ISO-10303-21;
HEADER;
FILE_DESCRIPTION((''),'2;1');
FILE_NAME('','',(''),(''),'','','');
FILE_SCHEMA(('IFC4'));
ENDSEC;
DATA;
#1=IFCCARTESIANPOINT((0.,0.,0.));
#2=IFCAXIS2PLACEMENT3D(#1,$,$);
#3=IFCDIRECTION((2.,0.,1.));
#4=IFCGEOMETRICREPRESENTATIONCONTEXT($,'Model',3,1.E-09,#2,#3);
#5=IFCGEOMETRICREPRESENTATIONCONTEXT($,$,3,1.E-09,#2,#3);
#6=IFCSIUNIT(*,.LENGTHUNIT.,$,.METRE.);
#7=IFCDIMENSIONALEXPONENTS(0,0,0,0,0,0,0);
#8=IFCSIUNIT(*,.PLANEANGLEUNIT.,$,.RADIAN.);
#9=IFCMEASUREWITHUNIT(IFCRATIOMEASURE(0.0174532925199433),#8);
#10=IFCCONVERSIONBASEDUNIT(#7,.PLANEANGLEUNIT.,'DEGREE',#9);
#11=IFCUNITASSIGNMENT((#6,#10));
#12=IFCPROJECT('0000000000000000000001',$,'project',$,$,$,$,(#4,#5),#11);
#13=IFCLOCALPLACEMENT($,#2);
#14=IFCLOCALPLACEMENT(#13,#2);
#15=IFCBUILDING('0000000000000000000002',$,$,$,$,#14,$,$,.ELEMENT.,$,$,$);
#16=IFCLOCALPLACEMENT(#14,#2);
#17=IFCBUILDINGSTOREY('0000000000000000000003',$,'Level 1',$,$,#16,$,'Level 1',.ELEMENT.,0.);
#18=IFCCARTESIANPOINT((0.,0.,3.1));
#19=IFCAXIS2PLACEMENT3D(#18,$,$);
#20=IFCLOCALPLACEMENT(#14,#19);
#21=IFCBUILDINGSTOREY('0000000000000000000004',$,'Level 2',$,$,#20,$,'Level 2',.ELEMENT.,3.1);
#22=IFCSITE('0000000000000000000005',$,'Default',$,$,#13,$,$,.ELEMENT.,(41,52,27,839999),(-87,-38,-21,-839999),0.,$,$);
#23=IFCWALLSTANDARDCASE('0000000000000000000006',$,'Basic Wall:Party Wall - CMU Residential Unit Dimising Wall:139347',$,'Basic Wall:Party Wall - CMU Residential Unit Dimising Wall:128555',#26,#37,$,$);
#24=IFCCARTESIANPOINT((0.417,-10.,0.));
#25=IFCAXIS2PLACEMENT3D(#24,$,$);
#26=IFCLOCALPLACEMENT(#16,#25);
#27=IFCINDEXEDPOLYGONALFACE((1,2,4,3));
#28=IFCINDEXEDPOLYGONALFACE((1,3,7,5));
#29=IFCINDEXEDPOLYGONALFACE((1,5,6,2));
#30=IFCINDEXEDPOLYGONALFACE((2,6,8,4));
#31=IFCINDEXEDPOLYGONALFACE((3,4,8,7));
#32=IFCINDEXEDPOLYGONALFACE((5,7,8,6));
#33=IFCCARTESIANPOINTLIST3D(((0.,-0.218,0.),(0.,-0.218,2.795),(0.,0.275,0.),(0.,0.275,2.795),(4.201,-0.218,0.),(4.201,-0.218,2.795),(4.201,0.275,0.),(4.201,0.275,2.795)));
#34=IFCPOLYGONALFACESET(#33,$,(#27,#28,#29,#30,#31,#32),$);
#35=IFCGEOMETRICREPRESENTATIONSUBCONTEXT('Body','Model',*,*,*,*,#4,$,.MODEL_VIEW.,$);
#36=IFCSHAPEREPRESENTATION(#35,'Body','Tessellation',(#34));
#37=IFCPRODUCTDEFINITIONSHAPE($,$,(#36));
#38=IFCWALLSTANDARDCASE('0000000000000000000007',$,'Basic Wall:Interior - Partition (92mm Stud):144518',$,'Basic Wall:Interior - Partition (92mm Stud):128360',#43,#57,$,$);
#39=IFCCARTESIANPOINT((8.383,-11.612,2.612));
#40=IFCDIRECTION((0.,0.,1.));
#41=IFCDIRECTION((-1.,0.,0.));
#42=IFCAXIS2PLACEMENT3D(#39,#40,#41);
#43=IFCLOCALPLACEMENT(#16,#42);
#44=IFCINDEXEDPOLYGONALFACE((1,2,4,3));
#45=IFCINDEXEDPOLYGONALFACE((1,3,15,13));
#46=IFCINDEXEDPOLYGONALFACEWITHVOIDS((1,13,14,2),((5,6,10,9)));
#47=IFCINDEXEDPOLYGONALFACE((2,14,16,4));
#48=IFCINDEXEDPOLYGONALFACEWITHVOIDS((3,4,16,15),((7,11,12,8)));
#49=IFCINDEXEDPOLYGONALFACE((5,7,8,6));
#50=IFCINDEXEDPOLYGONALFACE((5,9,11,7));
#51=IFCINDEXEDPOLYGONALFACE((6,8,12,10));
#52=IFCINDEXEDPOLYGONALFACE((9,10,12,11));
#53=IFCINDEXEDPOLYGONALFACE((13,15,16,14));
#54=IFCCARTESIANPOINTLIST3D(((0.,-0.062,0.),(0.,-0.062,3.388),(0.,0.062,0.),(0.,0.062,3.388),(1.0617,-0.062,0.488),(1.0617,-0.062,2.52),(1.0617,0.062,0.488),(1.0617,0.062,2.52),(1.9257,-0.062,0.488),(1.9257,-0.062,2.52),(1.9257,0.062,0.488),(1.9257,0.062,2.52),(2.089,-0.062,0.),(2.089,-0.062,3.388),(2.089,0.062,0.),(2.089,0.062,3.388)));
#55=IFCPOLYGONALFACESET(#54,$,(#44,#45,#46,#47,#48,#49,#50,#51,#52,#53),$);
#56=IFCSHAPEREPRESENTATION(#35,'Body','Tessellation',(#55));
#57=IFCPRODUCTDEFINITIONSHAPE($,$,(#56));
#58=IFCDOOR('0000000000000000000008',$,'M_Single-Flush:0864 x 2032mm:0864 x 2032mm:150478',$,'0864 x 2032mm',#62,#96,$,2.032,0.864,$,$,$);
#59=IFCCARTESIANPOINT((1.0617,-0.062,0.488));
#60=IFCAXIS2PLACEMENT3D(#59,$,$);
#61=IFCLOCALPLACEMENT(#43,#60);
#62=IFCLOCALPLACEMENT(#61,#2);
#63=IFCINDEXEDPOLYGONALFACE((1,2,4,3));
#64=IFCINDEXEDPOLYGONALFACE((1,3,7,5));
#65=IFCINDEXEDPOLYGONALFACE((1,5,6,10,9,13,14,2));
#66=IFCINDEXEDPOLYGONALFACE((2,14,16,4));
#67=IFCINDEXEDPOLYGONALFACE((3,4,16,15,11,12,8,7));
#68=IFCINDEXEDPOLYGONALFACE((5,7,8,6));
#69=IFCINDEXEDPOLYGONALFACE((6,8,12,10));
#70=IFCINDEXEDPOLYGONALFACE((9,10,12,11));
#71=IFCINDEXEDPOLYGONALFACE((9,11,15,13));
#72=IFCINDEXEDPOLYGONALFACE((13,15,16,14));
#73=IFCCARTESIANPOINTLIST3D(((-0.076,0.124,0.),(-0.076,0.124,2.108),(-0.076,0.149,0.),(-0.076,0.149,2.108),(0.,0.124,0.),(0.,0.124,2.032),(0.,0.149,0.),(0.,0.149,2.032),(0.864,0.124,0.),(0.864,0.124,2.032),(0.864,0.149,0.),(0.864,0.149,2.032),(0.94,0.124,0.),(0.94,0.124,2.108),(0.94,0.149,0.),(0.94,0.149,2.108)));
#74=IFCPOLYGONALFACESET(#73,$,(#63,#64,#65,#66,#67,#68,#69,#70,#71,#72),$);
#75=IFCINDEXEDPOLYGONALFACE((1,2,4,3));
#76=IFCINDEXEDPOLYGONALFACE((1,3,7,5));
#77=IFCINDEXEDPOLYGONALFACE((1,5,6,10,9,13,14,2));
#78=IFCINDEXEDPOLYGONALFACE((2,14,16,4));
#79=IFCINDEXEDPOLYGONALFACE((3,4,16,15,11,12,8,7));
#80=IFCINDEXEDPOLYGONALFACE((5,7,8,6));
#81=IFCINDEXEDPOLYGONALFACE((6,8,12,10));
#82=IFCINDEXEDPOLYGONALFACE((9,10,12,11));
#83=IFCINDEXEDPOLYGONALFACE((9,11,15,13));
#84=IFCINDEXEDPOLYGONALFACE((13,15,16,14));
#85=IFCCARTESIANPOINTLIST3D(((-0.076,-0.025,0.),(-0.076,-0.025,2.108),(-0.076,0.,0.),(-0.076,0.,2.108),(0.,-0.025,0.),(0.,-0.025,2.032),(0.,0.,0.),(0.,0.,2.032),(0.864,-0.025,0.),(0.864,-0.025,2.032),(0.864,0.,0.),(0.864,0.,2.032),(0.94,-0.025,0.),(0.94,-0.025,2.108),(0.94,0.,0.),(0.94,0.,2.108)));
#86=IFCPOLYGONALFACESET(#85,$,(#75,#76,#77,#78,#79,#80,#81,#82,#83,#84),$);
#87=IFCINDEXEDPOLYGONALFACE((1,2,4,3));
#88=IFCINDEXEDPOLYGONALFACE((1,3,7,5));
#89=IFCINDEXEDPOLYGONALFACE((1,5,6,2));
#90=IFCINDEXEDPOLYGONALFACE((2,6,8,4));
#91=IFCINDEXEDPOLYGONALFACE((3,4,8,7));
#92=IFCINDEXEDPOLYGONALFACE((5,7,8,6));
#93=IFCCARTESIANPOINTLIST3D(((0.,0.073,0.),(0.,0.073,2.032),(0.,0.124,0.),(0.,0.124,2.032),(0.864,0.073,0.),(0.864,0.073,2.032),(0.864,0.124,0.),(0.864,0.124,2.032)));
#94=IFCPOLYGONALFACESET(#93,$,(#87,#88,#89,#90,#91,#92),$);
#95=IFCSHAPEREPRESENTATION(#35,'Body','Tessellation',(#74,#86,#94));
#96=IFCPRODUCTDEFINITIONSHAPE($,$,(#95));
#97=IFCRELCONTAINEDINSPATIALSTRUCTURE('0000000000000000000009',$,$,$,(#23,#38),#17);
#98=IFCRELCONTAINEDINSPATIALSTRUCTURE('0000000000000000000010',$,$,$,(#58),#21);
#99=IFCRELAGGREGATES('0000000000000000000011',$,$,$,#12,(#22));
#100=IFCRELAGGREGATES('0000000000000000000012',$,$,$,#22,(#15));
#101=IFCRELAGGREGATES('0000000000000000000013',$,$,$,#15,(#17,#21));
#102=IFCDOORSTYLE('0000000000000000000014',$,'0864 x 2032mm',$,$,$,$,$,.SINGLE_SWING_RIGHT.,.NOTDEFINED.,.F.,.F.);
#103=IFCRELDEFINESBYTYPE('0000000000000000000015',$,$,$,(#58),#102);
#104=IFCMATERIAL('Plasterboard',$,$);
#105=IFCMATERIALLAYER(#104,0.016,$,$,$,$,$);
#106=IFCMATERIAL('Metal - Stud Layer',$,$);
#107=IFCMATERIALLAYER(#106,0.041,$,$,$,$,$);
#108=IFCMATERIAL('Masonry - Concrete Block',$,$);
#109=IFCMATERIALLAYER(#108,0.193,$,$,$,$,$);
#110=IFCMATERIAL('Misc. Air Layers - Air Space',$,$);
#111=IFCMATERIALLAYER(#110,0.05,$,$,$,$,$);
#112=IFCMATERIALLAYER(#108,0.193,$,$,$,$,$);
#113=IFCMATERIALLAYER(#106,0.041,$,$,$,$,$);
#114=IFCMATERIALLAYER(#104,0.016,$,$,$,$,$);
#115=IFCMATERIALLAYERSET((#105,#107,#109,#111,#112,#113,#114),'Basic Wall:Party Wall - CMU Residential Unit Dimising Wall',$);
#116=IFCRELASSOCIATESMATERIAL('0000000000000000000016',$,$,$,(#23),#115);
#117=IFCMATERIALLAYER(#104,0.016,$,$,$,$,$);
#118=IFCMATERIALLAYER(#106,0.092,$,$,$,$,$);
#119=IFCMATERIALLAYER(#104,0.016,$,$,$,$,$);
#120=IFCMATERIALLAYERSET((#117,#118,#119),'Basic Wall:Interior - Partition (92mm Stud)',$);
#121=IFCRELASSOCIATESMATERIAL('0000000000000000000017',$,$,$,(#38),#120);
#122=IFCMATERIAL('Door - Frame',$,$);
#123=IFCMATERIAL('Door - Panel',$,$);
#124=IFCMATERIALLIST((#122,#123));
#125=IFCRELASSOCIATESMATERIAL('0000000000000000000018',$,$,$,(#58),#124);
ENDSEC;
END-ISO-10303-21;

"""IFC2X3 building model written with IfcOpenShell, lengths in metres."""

from ifc_helpers import new_model, entity, si_unit, converted_unit, direction, frame, frame_2d, origin, origin_2d_with_axis, place, context, subcontext, project, spatial, polyline, rectangle, outline, extrude, clip, bounded_halfspace, source, transform, mapped, material, material_list, layer, layer_set, layer_usage, type_object, type_shapes, element, fill, save


model = new_model("IFC2X3")

# Units and contexts
model_context = context("Model", 3, precision=1e-09, world=origin(), true_north=direction((2.0, 0.0, 1.0)))
context_of_model = context(None, 3, precision=1e-09, world=origin(), true_north=direction((2.0, 0.0, 1.0)))
body_context = subcontext(model_context, "Body", "Model", "MODEL_VIEW")
ifc_project = project(units=[si_unit("LENGTHUNIT", "METRE"), converted_unit("PLANEANGLEUNIT", "DEGREE", entity("IfcRatioMeasure", 0.0174532925199433), si_unit("PLANEANGLEUNIT", "RADIAN"), dimensions=[0, 0, 0, 0, 0, 0, 0])], contexts=[model_context, context_of_model])

# Site, building, storey
site_placement = place(None, origin())
site = spatial("IfcSite", under=ifc_project, at=site_placement, Name="Default", CompositionType="ELEMENT", RefLatitude=(41, 52, 27, 839999), RefLongitude=(-87, -38, -21, -839999), RefElevation=0.0)
building_placement = place(site_placement, origin())
building = spatial("IfcBuilding", under=site, at=building_placement, CompositionType="ELEMENT")
storey_1_placement = place(building_placement, origin())
storey_1 = spatial("IfcBuildingStorey", under=building, at=storey_1_placement, Name="Level 1", LongName="Level 1", CompositionType="ELEMENT", Elevation=0.0)

# Wall
ifc_material_1 = material(Name="Plasterboard")
ifc_layer_1 = layer(ifc_material_1, 0.016)
ifc_material_2 = material(Name="Metal - Stud Layer")
ifc_layer_2 = layer(ifc_material_2, 0.041)
ifc_material_3 = material(Name="Masonry - Concrete Block")
ifc_layer_3 = layer(ifc_material_3, 0.193)
ifc_material_4 = material(Name="Misc. Air Layers - Air Space")
ifc_layer_4 = layer(ifc_material_4, 0.05)
ifc_layer_5 = layer(ifc_material_3, 0.193)
ifc_layer_6 = layer(ifc_material_2, 0.041)
ifc_layer_7 = layer(ifc_material_1, 0.016)
ifc_layer_set_1 = layer_set([ifc_layer_1, ifc_layer_2, ifc_layer_3, ifc_layer_4, ifc_layer_5, ifc_layer_6, ifc_layer_7], Name="Basic Wall:Party Wall - CMU Residential Unit Dimising Wall")
ifc_layer_usage_1 = layer_usage(ifc_layer_set_1, "AXIS2", "NEGATIVE", 0.275)
wall_1_placement = place(storey_1_placement, frame((0.417, -10.0, 0.0)))
element("IfcWallStandardCase", 1, at=wall_1_placement, inside=storey_1, material=ifc_layer_usage_1, Name="Basic Wall:Party Wall - CMU Residential Unit Dimising Wall:139347", ObjectType="Basic Wall:Party Wall - CMU Residential Unit Dimising Wall:128555", context=body_context, shape_type="Clipping", body=[
    clip(clip(extrude(rectangle(XDim=4.201, YDim=0.55, at=frame_2d((2.1005, 0.0), x_axis=(-1.0, 0.0))), origin(), (0.0, 0.0, 1.0), 2.795), bounded_halfspace(frame((0.0, -0.218, 0.0), z_axis=(0.0, 1.0, 0.0), x_axis=(-1.0, 0.0, 0.0)), True, frame((0.0, -0.218, 0.0), z_axis=(0.0, 1.0, 0.0), x_axis=(-1.0, 0.0, 0.0)), polyline([(0.0, 0.0), (0.0, 2.795), (-4.201, 2.795), (-4.201, 0.0), (0.0, 0.0)]))), bounded_halfspace(frame((4.201, 0.275, 0.0), z_axis=(-1.0, 0.0, 0.0), x_axis=(0.0, -1.0, 0.0)), True, frame((4.201, 0.275, 0.0), z_axis=(-1.0, 0.0, 0.0), x_axis=(0.0, -1.0, 0.0)), polyline([(0.0, 0.0), (0.493, 0.0), (0.493, 2.795), (0.0, 2.795), (0.0, 0.0)]))),
])

# Shared definitions
ifc_layer_8 = layer(ifc_material_1, 0.016)
ifc_layer_9 = layer(ifc_material_2, 0.092)
ifc_layer_10 = layer(ifc_material_1, 0.016)
ifc_layer_set_2 = layer_set([ifc_layer_8, ifc_layer_9, ifc_layer_10], Name="Basic Wall:Interior - Partition (92mm Stud)")
ifc_material_5 = material(Name="Door - Frame")
ifc_material_6 = material(Name="Door - Panel")

# Wall, opening
ifc_layer_usage_2 = layer_usage(ifc_layer_set_2, "AXIS2", "NEGATIVE", 0.062)
wall_2_placement = place(storey_1_placement, frame((8.383, -11.612, 2.612), z_axis=(0.0, 0.0, 1.0), x_axis=(-1.0, 0.0, 0.0)))
wall_2 = element("IfcWallStandardCase", 2, at=wall_2_placement, inside=storey_1, material=ifc_layer_usage_2, Name="Basic Wall:Interior - Partition (92mm Stud):144518", ObjectType="Basic Wall:Interior - Partition (92mm Stud):128360", context=body_context, shape_type="SweptSolid", body=[
    extrude(rectangle(XDim=2.089, YDim=0.124, at=frame_2d((1.0445, 0.0), x_axis=(-1.0, 0.0))), origin(), (0.0, 0.0, 1.0), 3.388),
])
opening_1_placement = place(wall_2_placement, frame((1.0617, -0.062, 0.488)))
opening_1 = element("IfcOpeningElement", 3, at=opening_1_placement, cuts=wall_2, ObjectType="Opening", context=body_context, shape_type="SweptSolid", body=[
    extrude(rectangle(XDim=0.864, YDim=2.032, at=frame_2d((1.016, 0.432), x_axis=(0.0, 1.0))), frame((0.0, 0.0, 0.0), z_axis=(0.0, 1.0, 0.0), x_axis=(0.0, 0.0, 1.0)), (0.0, 0.0, 1.0), 0.124),
])

# Shared definitions
storey_2_placement = place(building_placement, frame((0.0, 0.0, 3.1)))
storey_2 = spatial("IfcBuildingStorey", under=building, at=storey_2_placement, Name="Level 2", LongName="Level 2", CompositionType="ELEMENT", Elevation=3.1)

# Door
ifc_material_list_1 = material_list([ifc_material_5, ifc_material_6])
door_style_1 = type_object("IfcDoorStyle", Name="0864 x 2032mm", ConstructionType="NOTDEFINED", OperationType="SINGLE_SWING_RIGHT", ParameterTakesPrecedence=False, Sizeable=False)
shared_shape_1 = source(origin(), body_context, "Body", "SweptSolid", [
    extrude(outline(polyline([(-0.508, -1.073), (0.508, -1.073), (0.508, 1.035), (0.432, 1.035), (0.432, -0.997), (-0.432, -0.997), (-0.432, 1.035), (-0.508, 1.035), (-0.508, -1.073)])), frame((0.432, 0.124, 1.035), z_axis=(0.0, 1.0, 0.0), x_axis=(1.0, 0.0, 0.0)), (0.0, 0.0, 1.0), 0.025),
    extrude(outline(polyline([(-1.073, -0.508), (1.035, -0.508), (1.035, -0.432), (-0.997, -0.432), (-0.997, 0.432), (1.035, 0.432), (1.035, 0.508), (-1.073, 0.508), (-1.073, -0.508)])), frame((0.432, -0.025, 1.035), z_axis=(0.0, 1.0, 0.0), x_axis=(0.0, 0.0, -1.0)), (0.0, 0.0, 1.0), 0.025),
    extrude(rectangle(XDim=0.051, YDim=0.864, at=origin_2d_with_axis()), frame((0.432, 0.0985, 0.0), z_axis=(0.0, 0.0, 1.0), x_axis=(0.0, 1.0, 0.0)), (0.0, 0.0, 1.0), 2.032),
])
type_shapes(door_style_1, [shared_shape_1])
door_1_placement = place(opening_1_placement, origin())
door_1 = element("IfcDoor", 4, at=door_1_placement, inside=storey_2, type_object=door_style_1, material=ifc_material_list_1, Name="M_Single-Flush:0864 x 2032mm:0864 x 2032mm:150478", ObjectType="0864 x 2032mm", OverallHeight=2.032, OverallWidth=0.864, context=body_context, shape_type="MappedRepresentation", body=[
    mapped(shared_shape_1, transform((0.0, 0.0, 0.0), scale=1.0)),
])
fill(opening_1, door_1)

save(model, "model.ifc")
